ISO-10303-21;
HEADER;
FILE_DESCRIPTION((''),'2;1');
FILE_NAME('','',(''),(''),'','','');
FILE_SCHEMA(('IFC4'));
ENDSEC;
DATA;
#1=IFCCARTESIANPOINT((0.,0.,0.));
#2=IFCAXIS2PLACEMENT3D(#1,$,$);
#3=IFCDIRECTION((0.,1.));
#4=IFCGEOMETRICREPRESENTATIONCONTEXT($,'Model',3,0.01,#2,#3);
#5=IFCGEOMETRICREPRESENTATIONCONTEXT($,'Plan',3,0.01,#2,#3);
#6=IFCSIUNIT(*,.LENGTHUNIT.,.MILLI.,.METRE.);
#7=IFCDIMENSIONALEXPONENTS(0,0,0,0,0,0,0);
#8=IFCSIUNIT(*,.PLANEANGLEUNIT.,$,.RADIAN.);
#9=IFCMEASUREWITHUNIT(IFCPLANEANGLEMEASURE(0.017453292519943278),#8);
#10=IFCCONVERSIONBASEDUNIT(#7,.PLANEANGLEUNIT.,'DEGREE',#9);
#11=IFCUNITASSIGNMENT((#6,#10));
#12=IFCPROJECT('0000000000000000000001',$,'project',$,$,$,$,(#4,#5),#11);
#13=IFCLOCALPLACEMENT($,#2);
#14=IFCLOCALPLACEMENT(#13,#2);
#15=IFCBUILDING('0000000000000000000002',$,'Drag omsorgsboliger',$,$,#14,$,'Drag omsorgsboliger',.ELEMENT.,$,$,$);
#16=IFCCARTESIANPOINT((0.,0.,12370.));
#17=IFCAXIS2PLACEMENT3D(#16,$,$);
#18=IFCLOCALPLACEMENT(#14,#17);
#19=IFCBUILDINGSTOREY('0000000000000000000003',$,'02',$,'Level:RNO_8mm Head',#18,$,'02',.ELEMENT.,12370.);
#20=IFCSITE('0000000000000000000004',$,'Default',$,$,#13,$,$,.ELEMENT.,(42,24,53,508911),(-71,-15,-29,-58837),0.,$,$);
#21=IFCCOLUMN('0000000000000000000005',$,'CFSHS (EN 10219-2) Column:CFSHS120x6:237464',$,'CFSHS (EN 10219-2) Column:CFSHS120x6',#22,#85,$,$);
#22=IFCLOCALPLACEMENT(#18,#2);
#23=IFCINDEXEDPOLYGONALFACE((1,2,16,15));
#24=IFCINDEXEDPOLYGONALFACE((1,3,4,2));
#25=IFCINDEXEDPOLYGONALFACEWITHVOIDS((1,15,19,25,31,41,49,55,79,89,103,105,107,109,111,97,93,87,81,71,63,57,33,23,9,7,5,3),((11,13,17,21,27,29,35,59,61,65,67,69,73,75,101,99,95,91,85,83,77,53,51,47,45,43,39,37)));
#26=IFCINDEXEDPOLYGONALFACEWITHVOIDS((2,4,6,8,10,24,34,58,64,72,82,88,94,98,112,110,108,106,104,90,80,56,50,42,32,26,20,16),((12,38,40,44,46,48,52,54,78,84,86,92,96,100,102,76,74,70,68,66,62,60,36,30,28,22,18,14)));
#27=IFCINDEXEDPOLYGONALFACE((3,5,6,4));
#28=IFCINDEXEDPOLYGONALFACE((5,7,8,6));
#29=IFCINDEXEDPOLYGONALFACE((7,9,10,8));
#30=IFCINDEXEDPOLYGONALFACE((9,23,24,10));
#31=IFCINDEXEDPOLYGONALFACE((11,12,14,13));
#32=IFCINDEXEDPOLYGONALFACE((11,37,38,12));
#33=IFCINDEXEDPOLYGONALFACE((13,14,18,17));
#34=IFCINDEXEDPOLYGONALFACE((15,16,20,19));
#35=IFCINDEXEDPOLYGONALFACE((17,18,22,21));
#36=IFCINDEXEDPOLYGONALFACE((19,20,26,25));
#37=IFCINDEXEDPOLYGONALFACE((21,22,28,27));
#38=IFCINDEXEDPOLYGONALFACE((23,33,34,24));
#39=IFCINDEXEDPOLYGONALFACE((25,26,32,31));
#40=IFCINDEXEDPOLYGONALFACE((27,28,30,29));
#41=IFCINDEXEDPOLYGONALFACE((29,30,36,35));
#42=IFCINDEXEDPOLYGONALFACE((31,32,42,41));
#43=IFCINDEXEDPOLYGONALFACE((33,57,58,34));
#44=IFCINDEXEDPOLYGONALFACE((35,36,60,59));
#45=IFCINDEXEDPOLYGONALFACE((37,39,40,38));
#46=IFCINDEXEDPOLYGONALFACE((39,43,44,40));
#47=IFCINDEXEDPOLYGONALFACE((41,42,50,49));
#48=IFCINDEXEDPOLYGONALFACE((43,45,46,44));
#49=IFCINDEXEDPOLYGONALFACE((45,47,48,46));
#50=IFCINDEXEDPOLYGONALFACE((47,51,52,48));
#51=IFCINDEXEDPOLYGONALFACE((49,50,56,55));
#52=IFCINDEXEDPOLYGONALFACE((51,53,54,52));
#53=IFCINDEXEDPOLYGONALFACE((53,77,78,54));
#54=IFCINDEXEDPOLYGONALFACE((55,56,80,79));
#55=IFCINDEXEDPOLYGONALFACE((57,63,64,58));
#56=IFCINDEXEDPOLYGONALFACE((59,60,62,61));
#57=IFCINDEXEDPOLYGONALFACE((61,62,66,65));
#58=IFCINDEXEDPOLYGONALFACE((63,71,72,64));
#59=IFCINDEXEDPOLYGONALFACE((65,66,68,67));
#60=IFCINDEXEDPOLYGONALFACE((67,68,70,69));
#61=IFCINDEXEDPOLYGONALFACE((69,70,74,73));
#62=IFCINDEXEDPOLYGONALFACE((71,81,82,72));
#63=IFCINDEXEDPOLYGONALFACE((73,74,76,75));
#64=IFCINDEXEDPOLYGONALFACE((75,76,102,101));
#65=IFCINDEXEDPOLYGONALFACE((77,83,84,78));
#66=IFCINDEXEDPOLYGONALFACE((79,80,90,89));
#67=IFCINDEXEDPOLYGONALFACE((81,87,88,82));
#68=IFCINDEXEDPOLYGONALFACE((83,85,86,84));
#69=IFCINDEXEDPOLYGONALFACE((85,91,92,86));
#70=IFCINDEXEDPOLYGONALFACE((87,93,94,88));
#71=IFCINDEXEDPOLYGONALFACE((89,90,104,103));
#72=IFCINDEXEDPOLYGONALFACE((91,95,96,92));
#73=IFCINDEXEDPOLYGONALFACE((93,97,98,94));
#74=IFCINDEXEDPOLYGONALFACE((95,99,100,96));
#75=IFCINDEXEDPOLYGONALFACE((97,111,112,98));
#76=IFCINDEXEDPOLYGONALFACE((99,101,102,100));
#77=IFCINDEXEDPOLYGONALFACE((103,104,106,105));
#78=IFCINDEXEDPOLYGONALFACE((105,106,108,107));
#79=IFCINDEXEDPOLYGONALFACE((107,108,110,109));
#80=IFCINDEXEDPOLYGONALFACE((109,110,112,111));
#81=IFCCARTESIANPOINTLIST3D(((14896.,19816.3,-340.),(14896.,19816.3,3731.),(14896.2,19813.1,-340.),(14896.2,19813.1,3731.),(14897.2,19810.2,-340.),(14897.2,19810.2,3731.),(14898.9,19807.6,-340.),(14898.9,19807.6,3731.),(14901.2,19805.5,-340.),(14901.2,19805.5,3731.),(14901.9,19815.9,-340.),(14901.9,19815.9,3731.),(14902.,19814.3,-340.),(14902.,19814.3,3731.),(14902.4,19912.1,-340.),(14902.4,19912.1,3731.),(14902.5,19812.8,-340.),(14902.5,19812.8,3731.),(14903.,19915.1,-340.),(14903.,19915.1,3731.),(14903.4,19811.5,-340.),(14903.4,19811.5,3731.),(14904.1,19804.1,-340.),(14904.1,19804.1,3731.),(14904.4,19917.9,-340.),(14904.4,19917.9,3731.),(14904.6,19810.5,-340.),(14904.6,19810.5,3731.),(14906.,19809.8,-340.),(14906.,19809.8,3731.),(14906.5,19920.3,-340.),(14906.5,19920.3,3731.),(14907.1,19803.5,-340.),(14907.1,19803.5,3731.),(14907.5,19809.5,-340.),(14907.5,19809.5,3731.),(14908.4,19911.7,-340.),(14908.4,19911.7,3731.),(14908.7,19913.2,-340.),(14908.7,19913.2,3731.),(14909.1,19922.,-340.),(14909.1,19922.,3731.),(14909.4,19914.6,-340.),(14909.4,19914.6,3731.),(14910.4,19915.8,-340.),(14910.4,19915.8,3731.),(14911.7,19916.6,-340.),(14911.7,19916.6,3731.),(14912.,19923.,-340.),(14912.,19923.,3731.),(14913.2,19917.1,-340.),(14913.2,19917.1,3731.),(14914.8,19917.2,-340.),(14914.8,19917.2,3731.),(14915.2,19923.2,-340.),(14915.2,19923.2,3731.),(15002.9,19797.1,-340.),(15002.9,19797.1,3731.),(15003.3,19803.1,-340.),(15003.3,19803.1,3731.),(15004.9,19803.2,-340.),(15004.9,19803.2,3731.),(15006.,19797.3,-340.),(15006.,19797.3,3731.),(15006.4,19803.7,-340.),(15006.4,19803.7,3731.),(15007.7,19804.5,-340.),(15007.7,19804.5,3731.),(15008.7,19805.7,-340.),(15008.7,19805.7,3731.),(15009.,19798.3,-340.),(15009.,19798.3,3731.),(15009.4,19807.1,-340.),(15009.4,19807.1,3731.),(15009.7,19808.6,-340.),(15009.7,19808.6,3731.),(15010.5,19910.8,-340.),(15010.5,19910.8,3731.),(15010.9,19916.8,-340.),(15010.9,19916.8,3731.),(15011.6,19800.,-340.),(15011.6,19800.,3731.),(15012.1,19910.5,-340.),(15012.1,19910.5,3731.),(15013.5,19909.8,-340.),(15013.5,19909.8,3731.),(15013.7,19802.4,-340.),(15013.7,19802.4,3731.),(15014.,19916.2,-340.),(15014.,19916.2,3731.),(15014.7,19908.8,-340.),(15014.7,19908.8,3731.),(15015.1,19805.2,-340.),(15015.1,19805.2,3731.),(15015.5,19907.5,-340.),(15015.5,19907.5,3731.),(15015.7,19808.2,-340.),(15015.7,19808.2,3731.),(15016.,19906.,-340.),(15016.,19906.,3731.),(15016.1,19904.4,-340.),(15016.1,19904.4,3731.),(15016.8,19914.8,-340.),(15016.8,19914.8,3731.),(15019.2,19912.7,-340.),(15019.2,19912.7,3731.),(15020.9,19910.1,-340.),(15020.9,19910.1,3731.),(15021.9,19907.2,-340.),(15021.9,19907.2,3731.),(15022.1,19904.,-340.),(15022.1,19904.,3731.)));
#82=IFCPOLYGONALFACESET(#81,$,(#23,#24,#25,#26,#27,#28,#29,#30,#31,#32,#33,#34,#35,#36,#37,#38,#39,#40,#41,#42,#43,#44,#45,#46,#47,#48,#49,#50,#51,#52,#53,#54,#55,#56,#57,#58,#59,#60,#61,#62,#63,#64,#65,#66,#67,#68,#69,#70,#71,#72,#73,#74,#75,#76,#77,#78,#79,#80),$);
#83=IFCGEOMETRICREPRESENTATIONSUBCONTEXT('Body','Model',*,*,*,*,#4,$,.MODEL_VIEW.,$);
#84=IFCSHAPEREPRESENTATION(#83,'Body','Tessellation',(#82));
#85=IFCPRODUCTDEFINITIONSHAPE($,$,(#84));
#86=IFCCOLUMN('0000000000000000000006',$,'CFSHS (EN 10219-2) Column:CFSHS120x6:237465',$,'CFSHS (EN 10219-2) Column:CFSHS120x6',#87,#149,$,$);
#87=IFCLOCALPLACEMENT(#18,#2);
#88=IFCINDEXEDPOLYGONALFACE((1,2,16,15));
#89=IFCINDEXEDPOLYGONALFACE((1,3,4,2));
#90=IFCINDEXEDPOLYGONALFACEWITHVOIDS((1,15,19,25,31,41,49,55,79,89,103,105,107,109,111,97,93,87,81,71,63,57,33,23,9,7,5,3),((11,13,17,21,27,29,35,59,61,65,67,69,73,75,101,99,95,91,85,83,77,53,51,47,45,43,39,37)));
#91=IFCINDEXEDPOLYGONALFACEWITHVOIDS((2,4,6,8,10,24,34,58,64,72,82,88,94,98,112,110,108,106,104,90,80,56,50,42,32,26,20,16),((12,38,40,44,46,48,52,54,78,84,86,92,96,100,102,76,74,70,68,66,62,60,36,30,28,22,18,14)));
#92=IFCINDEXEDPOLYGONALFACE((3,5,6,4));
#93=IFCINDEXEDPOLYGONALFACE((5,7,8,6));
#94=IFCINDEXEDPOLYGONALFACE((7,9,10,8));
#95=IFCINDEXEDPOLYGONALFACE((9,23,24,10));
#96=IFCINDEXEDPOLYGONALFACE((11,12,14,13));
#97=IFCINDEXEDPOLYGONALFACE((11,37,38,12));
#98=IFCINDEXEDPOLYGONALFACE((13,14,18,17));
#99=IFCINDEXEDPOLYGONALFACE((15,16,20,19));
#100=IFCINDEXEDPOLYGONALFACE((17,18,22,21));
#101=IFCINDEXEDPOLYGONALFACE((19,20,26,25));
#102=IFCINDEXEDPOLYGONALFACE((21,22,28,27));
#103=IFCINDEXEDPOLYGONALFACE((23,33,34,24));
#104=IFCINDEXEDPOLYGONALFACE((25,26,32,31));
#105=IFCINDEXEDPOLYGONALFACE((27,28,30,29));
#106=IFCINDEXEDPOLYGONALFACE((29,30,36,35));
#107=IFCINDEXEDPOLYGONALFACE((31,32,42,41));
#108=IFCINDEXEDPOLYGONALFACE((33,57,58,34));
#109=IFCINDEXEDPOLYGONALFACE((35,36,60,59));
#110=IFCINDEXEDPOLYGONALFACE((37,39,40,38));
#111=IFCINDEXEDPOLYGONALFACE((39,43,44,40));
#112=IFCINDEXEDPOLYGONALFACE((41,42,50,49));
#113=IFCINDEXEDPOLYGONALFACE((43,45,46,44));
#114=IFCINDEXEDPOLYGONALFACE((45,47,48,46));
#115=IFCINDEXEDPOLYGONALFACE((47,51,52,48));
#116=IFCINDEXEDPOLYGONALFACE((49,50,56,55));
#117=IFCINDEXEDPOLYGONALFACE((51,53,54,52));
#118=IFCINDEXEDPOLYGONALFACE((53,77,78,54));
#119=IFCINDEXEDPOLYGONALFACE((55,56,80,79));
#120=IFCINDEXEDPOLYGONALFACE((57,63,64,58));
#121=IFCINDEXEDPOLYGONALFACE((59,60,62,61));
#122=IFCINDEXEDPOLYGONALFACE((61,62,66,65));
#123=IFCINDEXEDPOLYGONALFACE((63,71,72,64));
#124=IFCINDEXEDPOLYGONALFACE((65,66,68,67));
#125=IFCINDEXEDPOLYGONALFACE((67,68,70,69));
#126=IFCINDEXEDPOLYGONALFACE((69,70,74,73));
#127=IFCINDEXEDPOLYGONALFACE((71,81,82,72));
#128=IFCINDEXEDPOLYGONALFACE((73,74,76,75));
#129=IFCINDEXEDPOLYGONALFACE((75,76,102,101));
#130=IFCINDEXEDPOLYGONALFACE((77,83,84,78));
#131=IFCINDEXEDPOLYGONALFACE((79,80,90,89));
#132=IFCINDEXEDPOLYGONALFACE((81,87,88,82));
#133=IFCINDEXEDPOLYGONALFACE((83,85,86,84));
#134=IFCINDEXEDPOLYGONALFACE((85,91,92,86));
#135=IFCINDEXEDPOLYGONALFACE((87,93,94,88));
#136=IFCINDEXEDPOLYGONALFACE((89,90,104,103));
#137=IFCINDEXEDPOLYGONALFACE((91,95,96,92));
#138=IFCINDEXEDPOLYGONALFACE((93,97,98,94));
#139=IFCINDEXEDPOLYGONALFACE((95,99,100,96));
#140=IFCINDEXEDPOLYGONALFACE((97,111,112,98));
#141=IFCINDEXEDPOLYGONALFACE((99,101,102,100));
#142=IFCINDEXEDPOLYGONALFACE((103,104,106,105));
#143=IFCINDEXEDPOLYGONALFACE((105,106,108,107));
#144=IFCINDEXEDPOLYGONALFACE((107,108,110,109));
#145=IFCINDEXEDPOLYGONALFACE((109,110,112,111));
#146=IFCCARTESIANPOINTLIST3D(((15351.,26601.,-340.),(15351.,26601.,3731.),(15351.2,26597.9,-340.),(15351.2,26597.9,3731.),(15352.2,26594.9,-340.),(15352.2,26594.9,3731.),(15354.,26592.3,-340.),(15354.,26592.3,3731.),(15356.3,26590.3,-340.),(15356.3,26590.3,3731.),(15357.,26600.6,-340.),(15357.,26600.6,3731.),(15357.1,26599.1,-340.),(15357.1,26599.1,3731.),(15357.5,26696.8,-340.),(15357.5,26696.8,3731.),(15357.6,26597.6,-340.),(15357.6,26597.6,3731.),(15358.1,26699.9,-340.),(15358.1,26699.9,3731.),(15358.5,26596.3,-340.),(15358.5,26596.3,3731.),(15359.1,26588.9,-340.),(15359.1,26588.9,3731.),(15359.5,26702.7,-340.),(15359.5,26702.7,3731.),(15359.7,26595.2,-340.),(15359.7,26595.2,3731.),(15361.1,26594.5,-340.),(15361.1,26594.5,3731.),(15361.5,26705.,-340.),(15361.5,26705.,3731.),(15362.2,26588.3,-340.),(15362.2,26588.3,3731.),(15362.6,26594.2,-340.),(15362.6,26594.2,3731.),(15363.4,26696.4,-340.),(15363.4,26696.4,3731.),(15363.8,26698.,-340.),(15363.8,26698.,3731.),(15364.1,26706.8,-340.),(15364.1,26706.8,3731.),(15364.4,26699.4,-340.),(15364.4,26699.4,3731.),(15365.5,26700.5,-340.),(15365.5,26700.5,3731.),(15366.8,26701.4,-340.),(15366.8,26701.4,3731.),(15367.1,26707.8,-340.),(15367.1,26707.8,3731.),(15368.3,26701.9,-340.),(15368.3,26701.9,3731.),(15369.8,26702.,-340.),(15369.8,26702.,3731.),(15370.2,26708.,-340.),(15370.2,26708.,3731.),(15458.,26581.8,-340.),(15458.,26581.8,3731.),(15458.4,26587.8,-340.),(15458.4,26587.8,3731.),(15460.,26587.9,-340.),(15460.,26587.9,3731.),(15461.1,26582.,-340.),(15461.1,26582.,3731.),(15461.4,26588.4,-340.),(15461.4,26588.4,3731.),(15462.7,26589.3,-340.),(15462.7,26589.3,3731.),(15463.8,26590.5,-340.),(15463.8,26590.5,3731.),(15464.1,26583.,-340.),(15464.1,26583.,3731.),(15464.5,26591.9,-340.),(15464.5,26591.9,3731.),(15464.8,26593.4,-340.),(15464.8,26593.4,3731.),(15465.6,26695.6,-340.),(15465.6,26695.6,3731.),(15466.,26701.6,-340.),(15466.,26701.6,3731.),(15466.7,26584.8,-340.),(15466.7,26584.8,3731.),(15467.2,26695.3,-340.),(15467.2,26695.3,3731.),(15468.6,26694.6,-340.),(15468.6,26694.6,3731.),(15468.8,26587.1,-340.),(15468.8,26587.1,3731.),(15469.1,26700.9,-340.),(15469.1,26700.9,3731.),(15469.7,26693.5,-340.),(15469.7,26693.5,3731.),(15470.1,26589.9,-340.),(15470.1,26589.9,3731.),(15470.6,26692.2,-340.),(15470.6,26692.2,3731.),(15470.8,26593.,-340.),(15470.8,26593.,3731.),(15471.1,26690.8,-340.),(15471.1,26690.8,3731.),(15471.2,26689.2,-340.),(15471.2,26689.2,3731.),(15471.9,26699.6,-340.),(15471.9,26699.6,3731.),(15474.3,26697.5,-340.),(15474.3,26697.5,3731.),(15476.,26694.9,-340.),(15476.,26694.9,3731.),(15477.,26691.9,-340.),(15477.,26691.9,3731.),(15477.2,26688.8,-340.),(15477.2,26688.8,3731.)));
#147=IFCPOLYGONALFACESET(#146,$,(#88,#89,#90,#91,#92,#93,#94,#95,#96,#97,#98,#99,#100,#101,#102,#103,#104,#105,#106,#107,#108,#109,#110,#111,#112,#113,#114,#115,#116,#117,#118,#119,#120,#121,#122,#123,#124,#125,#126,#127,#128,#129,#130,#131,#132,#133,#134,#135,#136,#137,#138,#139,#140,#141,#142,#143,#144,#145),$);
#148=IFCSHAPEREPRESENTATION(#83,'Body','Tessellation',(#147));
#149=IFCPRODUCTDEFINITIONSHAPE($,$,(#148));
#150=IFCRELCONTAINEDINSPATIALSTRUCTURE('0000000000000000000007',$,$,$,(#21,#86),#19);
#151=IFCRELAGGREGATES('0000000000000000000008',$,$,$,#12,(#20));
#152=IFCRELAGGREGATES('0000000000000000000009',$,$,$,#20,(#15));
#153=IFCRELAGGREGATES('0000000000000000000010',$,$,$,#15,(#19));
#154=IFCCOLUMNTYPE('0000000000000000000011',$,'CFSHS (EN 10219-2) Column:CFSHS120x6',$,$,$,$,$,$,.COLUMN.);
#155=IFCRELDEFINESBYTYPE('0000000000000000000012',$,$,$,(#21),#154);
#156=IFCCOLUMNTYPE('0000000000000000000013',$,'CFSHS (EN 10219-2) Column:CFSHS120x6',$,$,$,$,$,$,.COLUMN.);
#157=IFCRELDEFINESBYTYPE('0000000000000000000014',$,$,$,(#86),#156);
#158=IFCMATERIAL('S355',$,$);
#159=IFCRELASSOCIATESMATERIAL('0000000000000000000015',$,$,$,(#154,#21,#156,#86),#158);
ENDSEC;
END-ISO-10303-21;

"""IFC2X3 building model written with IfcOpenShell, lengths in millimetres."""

from ifc_helpers import new_model, entity, si_unit, converted_unit, direction, frame, frame_2d, origin, place, context, subcontext, project, spatial, polyline, circle_curve, parameter, trimmed, segment, composite_curve, outline, extrude, source, transform, mapped, material, type_object, type_shapes, element, save


model = new_model("IFC2X3")

# Units and contexts
model_context = context("Model", 3, precision=0.01, world=origin(), true_north=direction((0.0, 1.0)))
plan_context = context("Plan", 3, precision=0.01, world=origin(), true_north=direction((0.0, 1.0)))
body_context = subcontext(model_context, "Body", "Model", "MODEL_VIEW")
ifc_project = project(units=[si_unit("LENGTHUNIT", "METRE", prefix="MILLI"), converted_unit("PLANEANGLEUNIT", "DEGREE", entity("IfcPlaneAngleMeasure", 0.017453292519943278), si_unit("PLANEANGLEUNIT", "RADIAN"), dimensions=[0, 0, 0, 0, 0, 0, 0])], contexts=[model_context, plan_context])

# Site, building, storey
site_placement = place(None, origin())
site = spatial("IfcSite", under=ifc_project, at=site_placement, Name="Default", CompositionType="ELEMENT", RefLatitude=(42, 24, 53, 508911), RefLongitude=(-71, -15, -29, -58837), RefElevation=0.0)
building_placement = place(site_placement, origin())
building = spatial("IfcBuilding", under=site, at=building_placement, Name="Drag omsorgsboliger", LongName="Drag omsorgsboliger", CompositionType="ELEMENT")
storey_placement = place(building_placement, frame((0.0, 0.0, 12370.0)))
storey = spatial("IfcBuildingStorey", under=building, at=storey_placement, Name="02", ObjectType="Level:RNO_8mm Head", LongName="02", CompositionType="ELEMENT", Elevation=12370.0)

# Columns
ifc_material = material(Name="S355")
column_type_1 = type_object("IfcColumnType", Name="CFSHS (EN 10219-2) Column:CFSHS120x6", PredefinedType="COLUMN", material=ifc_material)
shared_shape_1 = source(origin(), body_context, "Body", "SweptSolid", [
    extrude(outline(composite_curve([segment(polyline([(-48.0, -60.0), (48.0, -60.0)]), True, "CONTINUOUS"), segment(trimmed(circle_curve(frame_2d((48.0, -48.0), x_axis=(-1.0, 0.0)), 12.0), [parameter(90.0)], [parameter(180.0)], True, "PARAMETER"), True, "CONTINUOUS"), segment(polyline([(60.0, -48.0), (60.0, 48.0)]), True, "CONTINUOUS"), segment(trimmed(circle_curve(frame_2d((48.0, 48.0), x_axis=(-1.0, 0.0)), 12.0), [parameter(180.0)], [parameter(270.0)], True, "PARAMETER"), True, "CONTINUOUS"), segment(polyline([(48.0, 60.0), (-48.0, 60.0)]), True, "CONTINUOUS"), segment(trimmed(circle_curve(frame_2d((-48.0, 48.0), x_axis=(-1.0, 0.0)), 12.0), [parameter(270.0)], [parameter(360.0)], True, "PARAMETER"), True, "CONTINUOUS"), segment(polyline([(-60.0, 48.0), (-60.0, -48.0)]), True, "CONTINUOUS"), segment(trimmed(circle_curve(frame_2d((-48.0, -48.0), x_axis=(-1.0, 0.0)), 12.0), [parameter(360.0)], [parameter(90.0)], True, "PARAMETER"), True, "CONTINUOUS")], self_intersect=False), holes=[composite_curve([segment(trimmed(circle_curve(frame_2d((-48.0, -48.0), x_axis=(-1.0, 0.0)), 6.0), [parameter(360.0)], [parameter(90.0)], True, "PARAMETER"), False, "CONTINUOUS"), segment(polyline([(-54.0, -48.0), (-54.0, 48.0)]), True, "CONTINUOUS"), segment(trimmed(circle_curve(frame_2d((-48.0, 48.0), x_axis=(-1.0, 0.0)), 6.0), [parameter(270.0)], [parameter(360.0)], True, "PARAMETER"), False, "CONTINUOUS"), segment(polyline([(-48.0, 54.0), (48.0, 54.0)]), True, "CONTINUOUS"), segment(trimmed(circle_curve(frame_2d((48.0, 48.0), x_axis=(-1.0, 0.0)), 6.0), [parameter(180.0)], [parameter(270.0)], True, "PARAMETER"), False, "CONTINUOUS"), segment(polyline([(54.0, 48.0), (54.0, -48.0)]), True, "CONTINUOUS"), segment(trimmed(circle_curve(frame_2d((48.0, -48.0), x_axis=(-1.0, 0.0)), 6.0), [parameter(90.0)], [parameter(180.0)], True, "PARAMETER"), False, "CONTINUOUS"), segment(polyline([(48.0, -54.0), (-48.0, -54.0)]), True, "CONTINUOUS")], self_intersect=False)]), frame((14959.0, 19860.2, 12030.0), z_axis=(0.0, 0.0, 1.0), x_axis=(-0.997758, 0.066923, 0.0)), (0.0, 0.0, 1.0), 4071.0),
])
type_shapes(column_type_1, [shared_shape_1])
column_1_placement = place(storey_placement, frame((0.0, 0.0, -12370.0)))
element("IfcColumn", 1, at=column_1_placement, inside=storey, type_object=column_type_1, material=ifc_material, Name="CFSHS (EN 10219-2) Column:CFSHS120x6:237464", ObjectType="CFSHS (EN 10219-2) Column:CFSHS120x6", context=body_context, shape_type="MappedRepresentation", body=[
    mapped(shared_shape_1, transform((0.0, 0.0, 0.0), scale=1.0)),
])
column_type_2 = type_object("IfcColumnType", Name="CFSHS (EN 10219-2) Column:CFSHS120x6", PredefinedType="COLUMN", material=ifc_material)
shared_shape_2 = source(origin(), body_context, "Body", "SweptSolid", [
    extrude(outline(composite_curve([segment(polyline([(-48.0, -60.0), (48.0, -60.0)]), True, "CONTINUOUS"), segment(trimmed(circle_curve(frame_2d((48.0, -48.0), x_axis=(-1.0, 0.0)), 12.0), [parameter(90.0)], [parameter(180.0)], True, "PARAMETER"), True, "CONTINUOUS"), segment(polyline([(60.0, -48.0), (60.0, 48.0)]), True, "CONTINUOUS"), segment(trimmed(circle_curve(frame_2d((48.0, 48.0), x_axis=(-1.0, 0.0)), 12.0), [parameter(180.0)], [parameter(270.0)], True, "PARAMETER"), True, "CONTINUOUS"), segment(polyline([(48.0, 60.0), (-48.0, 60.0)]), True, "CONTINUOUS"), segment(trimmed(circle_curve(frame_2d((-48.0, 48.0), x_axis=(-1.0, 0.0)), 12.0), [parameter(270.0)], [parameter(360.0)], True, "PARAMETER"), True, "CONTINUOUS"), segment(polyline([(-60.0, 48.0), (-60.0, -48.0)]), True, "CONTINUOUS"), segment(trimmed(circle_curve(frame_2d((-48.0, -48.0), x_axis=(-1.0, 0.0)), 12.0), [parameter(360.0)], [parameter(90.0)], True, "PARAMETER"), True, "CONTINUOUS")], self_intersect=False), holes=[composite_curve([segment(trimmed(circle_curve(frame_2d((-48.0, -48.0), x_axis=(-1.0, 0.0)), 6.0), [parameter(360.0)], [parameter(90.0)], True, "PARAMETER"), False, "CONTINUOUS"), segment(polyline([(-54.0, -48.0), (-54.0, 48.0)]), True, "CONTINUOUS"), segment(trimmed(circle_curve(frame_2d((-48.0, 48.0), x_axis=(-1.0, 0.0)), 6.0), [parameter(270.0)], [parameter(360.0)], True, "PARAMETER"), False, "CONTINUOUS"), segment(polyline([(-48.0, 54.0), (48.0, 54.0)]), True, "CONTINUOUS"), segment(trimmed(circle_curve(frame_2d((48.0, 48.0), x_axis=(-1.0, 0.0)), 6.0), [parameter(180.0)], [parameter(270.0)], True, "PARAMETER"), False, "CONTINUOUS"), segment(polyline([(54.0, 48.0), (54.0, -48.0)]), True, "CONTINUOUS"), segment(trimmed(circle_curve(frame_2d((48.0, -48.0), x_axis=(-1.0, 0.0)), 6.0), [parameter(90.0)], [parameter(180.0)], True, "PARAMETER"), False, "CONTINUOUS"), segment(polyline([(48.0, -54.0), (-48.0, -54.0)]), True, "CONTINUOUS")], self_intersect=False)]), frame((15414.1, 26644.9, 12030.0), z_axis=(0.0, 0.0, 1.0), x_axis=(-0.997758, 0.066923, 0.0)), (0.0, 0.0, 1.0), 4071.0),
])
type_shapes(column_type_2, [shared_shape_2])
column_2_placement = place(storey_placement, frame((0.0, 0.0, -12370.0)))
element("IfcColumn", 2, at=column_2_placement, inside=storey, type_object=column_type_2, material=ifc_material, Name="CFSHS (EN 10219-2) Column:CFSHS120x6:237465", ObjectType="CFSHS (EN 10219-2) Column:CFSHS120x6", context=body_context, shape_type="MappedRepresentation", body=[
    mapped(shared_shape_2, transform((0.0, 0.0, 0.0), scale=1.0)),
])

save(model, "model.ifc")
